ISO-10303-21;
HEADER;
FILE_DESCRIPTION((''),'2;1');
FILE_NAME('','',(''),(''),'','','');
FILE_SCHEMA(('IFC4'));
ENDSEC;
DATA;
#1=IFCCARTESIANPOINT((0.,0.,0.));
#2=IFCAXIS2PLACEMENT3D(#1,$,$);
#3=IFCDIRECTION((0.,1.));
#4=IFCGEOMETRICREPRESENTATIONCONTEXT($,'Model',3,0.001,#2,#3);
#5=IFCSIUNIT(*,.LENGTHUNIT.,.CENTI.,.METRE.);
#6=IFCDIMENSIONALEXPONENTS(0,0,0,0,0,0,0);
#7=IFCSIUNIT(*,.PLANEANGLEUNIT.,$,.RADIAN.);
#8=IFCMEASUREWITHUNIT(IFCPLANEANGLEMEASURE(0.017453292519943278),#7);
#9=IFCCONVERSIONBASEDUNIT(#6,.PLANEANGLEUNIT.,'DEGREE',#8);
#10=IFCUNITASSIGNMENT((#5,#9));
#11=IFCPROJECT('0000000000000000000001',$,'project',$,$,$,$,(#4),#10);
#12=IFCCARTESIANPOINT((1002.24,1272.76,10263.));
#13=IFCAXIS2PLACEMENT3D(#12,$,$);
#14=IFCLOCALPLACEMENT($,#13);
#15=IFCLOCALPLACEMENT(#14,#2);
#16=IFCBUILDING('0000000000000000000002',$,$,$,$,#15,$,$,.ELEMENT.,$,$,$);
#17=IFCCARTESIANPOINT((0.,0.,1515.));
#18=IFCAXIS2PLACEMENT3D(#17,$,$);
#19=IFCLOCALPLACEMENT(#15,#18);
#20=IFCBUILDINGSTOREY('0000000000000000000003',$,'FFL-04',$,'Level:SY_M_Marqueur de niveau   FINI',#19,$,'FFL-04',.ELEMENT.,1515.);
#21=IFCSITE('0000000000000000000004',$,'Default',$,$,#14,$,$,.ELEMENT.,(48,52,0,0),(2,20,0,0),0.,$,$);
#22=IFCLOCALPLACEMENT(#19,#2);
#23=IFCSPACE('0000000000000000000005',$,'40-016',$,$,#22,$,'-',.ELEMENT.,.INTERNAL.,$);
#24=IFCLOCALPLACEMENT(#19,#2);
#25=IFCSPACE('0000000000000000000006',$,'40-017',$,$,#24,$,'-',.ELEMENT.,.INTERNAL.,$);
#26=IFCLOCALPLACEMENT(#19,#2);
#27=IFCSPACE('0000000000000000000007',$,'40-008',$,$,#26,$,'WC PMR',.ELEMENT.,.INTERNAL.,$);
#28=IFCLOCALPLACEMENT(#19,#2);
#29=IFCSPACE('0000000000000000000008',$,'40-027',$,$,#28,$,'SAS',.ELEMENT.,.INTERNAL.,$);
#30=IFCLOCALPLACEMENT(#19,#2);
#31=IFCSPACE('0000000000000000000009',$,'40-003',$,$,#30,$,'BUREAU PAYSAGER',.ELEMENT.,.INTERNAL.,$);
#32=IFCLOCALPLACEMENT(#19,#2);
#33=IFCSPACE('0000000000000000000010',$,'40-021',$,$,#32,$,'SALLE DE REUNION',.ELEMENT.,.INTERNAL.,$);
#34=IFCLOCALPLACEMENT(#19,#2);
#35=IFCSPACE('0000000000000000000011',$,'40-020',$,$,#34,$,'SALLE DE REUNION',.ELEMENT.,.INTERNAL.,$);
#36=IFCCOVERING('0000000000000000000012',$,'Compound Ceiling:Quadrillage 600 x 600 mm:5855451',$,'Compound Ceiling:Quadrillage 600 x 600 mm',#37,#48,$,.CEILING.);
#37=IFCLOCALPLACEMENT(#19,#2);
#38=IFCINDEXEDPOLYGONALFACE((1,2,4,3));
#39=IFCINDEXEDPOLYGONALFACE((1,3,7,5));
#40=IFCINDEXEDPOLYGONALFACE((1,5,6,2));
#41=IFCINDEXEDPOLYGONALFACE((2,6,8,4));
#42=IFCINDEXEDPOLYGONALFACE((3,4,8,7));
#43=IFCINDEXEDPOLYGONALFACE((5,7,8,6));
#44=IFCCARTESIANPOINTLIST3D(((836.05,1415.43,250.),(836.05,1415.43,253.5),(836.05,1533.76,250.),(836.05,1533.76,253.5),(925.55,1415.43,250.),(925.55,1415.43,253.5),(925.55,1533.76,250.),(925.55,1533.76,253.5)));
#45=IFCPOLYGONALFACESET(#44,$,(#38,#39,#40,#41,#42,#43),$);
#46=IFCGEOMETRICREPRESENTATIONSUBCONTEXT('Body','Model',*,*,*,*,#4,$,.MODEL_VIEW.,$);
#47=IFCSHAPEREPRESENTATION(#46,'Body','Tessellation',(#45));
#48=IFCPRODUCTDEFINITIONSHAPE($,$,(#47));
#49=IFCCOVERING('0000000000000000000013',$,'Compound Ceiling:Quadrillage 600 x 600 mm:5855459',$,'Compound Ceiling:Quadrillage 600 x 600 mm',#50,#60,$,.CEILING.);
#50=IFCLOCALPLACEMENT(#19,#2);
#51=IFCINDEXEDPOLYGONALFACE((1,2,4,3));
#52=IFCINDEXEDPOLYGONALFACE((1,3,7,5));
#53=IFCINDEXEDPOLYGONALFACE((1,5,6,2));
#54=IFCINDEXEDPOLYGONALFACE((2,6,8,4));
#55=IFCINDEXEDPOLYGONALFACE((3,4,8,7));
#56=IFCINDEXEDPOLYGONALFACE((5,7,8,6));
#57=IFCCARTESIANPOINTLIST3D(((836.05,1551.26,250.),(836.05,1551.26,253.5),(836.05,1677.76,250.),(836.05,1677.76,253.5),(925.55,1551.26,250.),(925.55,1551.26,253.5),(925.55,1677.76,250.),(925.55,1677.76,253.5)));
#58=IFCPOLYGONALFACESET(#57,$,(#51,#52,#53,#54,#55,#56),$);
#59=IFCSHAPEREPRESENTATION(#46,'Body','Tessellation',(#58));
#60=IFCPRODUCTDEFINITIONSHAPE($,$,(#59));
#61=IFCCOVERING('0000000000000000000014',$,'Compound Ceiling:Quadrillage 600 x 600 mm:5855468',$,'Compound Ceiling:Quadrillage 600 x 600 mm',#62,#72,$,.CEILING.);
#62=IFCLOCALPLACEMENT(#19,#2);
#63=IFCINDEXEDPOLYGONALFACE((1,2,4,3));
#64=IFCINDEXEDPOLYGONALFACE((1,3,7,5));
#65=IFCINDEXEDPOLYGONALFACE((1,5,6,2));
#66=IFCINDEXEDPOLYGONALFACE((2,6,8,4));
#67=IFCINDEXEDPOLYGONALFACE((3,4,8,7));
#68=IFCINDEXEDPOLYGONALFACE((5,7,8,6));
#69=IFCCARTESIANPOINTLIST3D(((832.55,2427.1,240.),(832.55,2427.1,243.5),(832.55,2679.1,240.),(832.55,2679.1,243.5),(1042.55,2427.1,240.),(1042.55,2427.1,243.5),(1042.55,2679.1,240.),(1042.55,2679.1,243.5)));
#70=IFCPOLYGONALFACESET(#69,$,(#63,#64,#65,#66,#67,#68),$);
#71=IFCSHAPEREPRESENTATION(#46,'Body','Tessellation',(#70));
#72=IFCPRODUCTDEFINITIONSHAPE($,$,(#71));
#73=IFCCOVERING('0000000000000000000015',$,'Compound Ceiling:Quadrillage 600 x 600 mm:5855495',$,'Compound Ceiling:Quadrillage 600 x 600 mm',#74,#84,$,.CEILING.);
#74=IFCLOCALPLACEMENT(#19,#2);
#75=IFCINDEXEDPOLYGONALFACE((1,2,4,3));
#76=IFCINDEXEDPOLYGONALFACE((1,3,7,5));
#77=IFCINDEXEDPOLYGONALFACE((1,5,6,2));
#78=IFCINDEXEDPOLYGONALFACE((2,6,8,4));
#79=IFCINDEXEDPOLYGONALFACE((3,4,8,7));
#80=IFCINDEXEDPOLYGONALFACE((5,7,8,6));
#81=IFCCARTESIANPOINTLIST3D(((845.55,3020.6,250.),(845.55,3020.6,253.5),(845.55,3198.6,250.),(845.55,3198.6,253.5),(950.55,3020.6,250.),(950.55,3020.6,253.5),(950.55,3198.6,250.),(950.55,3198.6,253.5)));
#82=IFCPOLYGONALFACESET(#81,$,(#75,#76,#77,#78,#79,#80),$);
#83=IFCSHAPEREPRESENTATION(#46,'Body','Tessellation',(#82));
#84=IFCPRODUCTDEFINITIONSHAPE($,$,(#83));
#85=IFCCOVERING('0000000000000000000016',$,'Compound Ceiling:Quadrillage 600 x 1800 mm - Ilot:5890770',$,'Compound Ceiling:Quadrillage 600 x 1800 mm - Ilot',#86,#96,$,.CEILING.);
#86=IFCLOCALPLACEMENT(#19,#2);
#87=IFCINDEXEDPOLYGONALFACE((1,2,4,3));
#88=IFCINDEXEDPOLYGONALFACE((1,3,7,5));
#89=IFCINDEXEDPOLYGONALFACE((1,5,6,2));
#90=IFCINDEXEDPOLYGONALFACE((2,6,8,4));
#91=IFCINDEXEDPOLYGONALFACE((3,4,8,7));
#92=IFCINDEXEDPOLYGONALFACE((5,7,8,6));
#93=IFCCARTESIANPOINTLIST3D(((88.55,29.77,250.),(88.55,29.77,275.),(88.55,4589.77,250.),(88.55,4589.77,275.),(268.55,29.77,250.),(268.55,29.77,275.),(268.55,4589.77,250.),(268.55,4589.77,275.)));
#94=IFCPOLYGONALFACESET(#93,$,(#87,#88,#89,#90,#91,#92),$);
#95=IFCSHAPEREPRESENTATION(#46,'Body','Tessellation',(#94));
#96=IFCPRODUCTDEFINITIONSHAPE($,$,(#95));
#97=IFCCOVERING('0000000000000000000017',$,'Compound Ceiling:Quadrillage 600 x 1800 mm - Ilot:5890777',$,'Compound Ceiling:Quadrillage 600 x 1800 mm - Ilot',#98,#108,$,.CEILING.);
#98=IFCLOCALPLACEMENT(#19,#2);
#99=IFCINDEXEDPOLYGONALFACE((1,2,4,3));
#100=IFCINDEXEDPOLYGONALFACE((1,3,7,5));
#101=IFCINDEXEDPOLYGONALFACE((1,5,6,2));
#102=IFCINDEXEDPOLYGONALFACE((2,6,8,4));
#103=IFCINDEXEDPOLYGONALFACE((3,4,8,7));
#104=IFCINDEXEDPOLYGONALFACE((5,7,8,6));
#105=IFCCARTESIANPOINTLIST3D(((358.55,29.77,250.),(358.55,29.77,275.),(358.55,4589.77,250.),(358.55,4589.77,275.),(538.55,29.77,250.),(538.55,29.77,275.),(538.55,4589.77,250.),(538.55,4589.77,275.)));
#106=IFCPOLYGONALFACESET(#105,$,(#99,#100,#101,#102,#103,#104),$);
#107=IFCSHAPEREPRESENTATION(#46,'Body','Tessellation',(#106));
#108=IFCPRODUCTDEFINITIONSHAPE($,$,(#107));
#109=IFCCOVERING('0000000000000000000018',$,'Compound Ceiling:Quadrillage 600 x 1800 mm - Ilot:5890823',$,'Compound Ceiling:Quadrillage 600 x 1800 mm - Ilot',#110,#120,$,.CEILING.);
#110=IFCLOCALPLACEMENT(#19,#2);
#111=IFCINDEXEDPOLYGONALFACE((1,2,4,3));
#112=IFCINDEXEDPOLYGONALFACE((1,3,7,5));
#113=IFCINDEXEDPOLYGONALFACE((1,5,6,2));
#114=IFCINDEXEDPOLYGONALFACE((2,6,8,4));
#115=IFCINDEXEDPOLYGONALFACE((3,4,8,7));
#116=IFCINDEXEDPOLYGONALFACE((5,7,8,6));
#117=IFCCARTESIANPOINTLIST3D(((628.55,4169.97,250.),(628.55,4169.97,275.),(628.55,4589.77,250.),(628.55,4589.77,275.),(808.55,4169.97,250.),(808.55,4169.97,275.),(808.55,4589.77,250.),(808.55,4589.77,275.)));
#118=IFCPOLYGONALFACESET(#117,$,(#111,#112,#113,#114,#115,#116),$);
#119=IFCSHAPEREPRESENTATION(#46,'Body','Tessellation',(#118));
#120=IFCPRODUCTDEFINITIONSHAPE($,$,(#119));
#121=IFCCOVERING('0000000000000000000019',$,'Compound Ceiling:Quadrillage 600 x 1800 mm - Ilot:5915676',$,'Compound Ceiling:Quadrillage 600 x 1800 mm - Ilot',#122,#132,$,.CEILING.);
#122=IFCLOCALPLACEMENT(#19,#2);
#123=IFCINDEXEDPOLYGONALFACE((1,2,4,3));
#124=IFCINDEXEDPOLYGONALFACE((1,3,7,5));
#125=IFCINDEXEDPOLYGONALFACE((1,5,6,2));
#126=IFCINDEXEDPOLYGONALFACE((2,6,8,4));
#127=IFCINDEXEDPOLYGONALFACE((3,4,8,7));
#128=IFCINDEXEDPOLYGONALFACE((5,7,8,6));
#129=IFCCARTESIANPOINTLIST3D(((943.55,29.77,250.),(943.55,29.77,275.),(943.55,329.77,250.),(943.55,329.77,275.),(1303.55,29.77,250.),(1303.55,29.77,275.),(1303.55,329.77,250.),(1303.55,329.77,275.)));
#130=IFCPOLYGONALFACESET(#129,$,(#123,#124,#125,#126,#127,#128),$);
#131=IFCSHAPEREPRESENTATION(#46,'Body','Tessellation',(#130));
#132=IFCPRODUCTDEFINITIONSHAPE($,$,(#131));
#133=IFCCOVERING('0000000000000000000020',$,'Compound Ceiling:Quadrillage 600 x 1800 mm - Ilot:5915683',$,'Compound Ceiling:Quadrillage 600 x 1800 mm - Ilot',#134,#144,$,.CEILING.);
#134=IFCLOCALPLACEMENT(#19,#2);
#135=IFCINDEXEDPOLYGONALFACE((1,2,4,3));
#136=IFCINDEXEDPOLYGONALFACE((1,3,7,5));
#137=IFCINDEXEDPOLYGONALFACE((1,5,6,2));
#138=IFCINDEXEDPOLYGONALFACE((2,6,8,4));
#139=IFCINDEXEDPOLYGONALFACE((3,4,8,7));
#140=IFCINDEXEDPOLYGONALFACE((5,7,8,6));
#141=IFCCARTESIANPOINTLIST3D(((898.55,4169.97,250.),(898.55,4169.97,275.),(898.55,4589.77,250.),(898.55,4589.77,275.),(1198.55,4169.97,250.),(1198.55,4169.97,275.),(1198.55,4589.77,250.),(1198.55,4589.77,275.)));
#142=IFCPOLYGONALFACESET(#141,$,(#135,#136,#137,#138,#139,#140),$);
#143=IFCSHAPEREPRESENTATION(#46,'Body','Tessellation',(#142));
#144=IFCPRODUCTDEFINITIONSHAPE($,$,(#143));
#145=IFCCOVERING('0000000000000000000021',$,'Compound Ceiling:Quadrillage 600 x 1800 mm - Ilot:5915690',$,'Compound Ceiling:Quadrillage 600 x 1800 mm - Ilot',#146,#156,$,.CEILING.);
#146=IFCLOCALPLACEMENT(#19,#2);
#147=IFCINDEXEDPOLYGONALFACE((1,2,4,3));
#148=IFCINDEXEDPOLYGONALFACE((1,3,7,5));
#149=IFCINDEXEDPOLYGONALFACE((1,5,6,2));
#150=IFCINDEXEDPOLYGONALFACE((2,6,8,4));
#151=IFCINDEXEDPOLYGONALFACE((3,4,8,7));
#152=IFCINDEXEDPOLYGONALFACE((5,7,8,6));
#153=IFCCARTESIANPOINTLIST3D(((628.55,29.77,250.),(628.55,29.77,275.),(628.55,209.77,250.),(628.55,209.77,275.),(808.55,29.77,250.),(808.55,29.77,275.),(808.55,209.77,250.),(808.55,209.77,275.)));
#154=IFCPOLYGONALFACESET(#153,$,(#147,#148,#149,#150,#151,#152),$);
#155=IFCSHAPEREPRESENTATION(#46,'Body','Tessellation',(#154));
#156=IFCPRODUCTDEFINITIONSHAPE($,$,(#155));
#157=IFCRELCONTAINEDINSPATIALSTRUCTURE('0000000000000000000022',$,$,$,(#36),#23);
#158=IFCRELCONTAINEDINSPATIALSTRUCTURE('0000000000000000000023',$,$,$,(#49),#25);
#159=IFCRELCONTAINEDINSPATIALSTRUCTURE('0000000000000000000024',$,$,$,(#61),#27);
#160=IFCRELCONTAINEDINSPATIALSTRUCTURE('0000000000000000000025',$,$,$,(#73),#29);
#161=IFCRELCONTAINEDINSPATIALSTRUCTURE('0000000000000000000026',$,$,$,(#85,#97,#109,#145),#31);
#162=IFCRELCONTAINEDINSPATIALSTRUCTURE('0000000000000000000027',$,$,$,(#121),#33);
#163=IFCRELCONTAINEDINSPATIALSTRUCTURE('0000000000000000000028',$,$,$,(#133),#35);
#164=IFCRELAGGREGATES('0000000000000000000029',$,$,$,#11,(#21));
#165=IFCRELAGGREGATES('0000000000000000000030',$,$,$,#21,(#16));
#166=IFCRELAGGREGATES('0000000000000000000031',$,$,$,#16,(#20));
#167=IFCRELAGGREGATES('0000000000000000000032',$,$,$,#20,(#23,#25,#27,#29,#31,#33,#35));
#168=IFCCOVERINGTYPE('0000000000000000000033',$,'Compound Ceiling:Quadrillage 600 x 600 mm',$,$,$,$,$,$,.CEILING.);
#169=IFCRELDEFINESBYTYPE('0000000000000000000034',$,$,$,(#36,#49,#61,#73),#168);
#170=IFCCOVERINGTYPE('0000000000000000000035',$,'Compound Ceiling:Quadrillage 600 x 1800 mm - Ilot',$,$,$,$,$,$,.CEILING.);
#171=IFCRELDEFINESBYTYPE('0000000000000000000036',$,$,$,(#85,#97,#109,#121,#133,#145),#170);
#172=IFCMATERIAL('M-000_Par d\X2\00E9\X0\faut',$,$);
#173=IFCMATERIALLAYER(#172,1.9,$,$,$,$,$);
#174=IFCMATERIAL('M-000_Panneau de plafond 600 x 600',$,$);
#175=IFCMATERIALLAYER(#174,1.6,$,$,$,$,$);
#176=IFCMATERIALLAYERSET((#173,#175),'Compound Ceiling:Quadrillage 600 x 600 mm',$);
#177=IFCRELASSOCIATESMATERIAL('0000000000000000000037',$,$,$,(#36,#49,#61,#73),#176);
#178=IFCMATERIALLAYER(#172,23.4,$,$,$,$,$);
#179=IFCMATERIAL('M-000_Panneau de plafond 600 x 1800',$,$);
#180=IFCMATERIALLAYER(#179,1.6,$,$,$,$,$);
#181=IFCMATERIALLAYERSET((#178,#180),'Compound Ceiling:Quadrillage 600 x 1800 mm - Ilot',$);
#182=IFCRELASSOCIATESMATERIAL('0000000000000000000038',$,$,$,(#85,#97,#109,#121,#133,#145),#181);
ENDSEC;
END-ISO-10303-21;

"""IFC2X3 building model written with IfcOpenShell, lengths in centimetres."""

from ifc_helpers import new_model, entity, si_unit, converted_unit, direction, frame, frame_2d, origin, origin_2d_with_axis, place, context, subcontext, project, spatial, polyline, rectangle, outline, extrude, material, layer, layer_set, layer_usage, type_object, element, save


model = new_model("IFC2X3")

# Units and contexts
model_context = context("Model", 3, precision=0.001, world=origin(), true_north=direction((0.0, 1.0)))
body_context = subcontext(model_context, "Body", "Model", "MODEL_VIEW")
ifc_project = project(units=[si_unit("LENGTHUNIT", "METRE", prefix="CENTI"), converted_unit("PLANEANGLEUNIT", "DEGREE", entity("IfcPlaneAngleMeasure", 0.017453292519943278), si_unit("PLANEANGLEUNIT", "RADIAN"), dimensions=[0, 0, 0, 0, 0, 0, 0])], contexts=[model_context])

# Site, building, storey
site_placement = place(None, frame((1002.24, 1272.76, 10263.0)))
site = spatial("IfcSite", under=ifc_project, at=site_placement, Name="Default", CompositionType="ELEMENT", RefLatitude=(48, 52, 0, 0), RefLongitude=(2, 20, 0, 0), RefElevation=0.0)
building_placement = place(site_placement, origin())
building = spatial("IfcBuilding", under=site, at=building_placement, CompositionType="ELEMENT")
storey_placement = place(building_placement, frame((0.0, 0.0, 1515.0)))
storey = spatial("IfcBuildingStorey", under=building, at=storey_placement, Name="FFL-04", ObjectType="Level:SY_M_Marqueur de niveau   FINI", LongName="FFL-04", CompositionType="ELEMENT", Elevation=1515.0)

# Shared definitions
ifc_material_1 = material(Name="M-000_Par défaut")
ifc_layer_1 = layer(ifc_material_1, 1.9)
ifc_material_2 = material(Name="M-000_Panneau de plafond 600 x 600")
ifc_layer_2 = layer(ifc_material_2, 1.6)
ifc_layer_set_1 = layer_set([ifc_layer_1, ifc_layer_2], Name="Compound Ceiling:Quadrillage 600 x 600 mm")
covering_type_1 = type_object("IfcCoveringType", Name="Compound Ceiling:Quadrillage 600 x 600 mm", PredefinedType="CEILING")

# Shared definitions
space_1_placement = place(storey_placement, origin())
space_1 = spatial("IfcSpace", under=storey, at=space_1_placement, Name="40-016", LongName="-", CompositionType="ELEMENT", InteriorOrExteriorSpace="INTERNAL")

# Covering
ifc_layer_usage_1 = layer_usage(ifc_layer_set_1, "AXIS3", "NEGATIVE", 3.5)
covering_1_placement = place(space_1_placement, origin())
element("IfcCovering", 1, at=covering_1_placement, inside=space_1, type_object=covering_type_1, material=ifc_layer_usage_1, Name="Compound Ceiling:Quadrillage 600 x 600 mm:5855451", ObjectType="Compound Ceiling:Quadrillage 600 x 600 mm", PredefinedType="CEILING", context=body_context, shape_type="SweptSolid", body=[
    extrude(rectangle(XDim=118.33, YDim=89.49, at=frame_2d((0.0, 0.0), x_axis=(1.0, 0.0))), frame((880.8, 1474.6, 250.0), z_axis=(0.0, 0.0, 1.0), x_axis=(0.0, -1.0, 0.0)), (0.0, 0.0, 1.0), 3.5),
])

# Shared definitions
space_2_placement = place(storey_placement, origin())
space_2 = spatial("IfcSpace", under=storey, at=space_2_placement, Name="40-017", LongName="-", CompositionType="ELEMENT", InteriorOrExteriorSpace="INTERNAL")

# Covering
ifc_layer_usage_2 = layer_usage(ifc_layer_set_1, "AXIS3", "NEGATIVE", 3.5)
covering_2_placement = place(space_2_placement, origin())
element("IfcCovering", 2, at=covering_2_placement, inside=space_2, type_object=covering_type_1, material=ifc_layer_usage_2, Name="Compound Ceiling:Quadrillage 600 x 600 mm:5855459", ObjectType="Compound Ceiling:Quadrillage 600 x 600 mm", PredefinedType="CEILING", context=body_context, shape_type="SweptSolid", body=[
    extrude(outline(polyline([(-63.25, -44.75), (63.25, -44.75), (63.25, 44.75), (-63.25, 44.75), (-63.25, -44.75)])), frame((880.8, 1614.51, 250.0), z_axis=(0.0, 0.0, 1.0), x_axis=(0.0, -1.0, 0.0)), (0.0, 0.0, 1.0), 3.5),
])

# Shared definitions
space_3_placement = place(storey_placement, origin())
space_3 = spatial("IfcSpace", under=storey, at=space_3_placement, Name="40-008", LongName="WC PMR", CompositionType="ELEMENT", InteriorOrExteriorSpace="INTERNAL")

# Covering
ifc_layer_usage_3 = layer_usage(ifc_layer_set_1, "AXIS3", "NEGATIVE", 3.5)
covering_3_placement = place(space_3_placement, origin())
element("IfcCovering", 3, at=covering_3_placement, inside=space_3, type_object=covering_type_1, material=ifc_layer_usage_3, Name="Compound Ceiling:Quadrillage 600 x 600 mm:5855468", ObjectType="Compound Ceiling:Quadrillage 600 x 600 mm", PredefinedType="CEILING", context=body_context, shape_type="SweptSolid", body=[
    extrude(rectangle(XDim=210.0, YDim=252.0, at=frame_2d((0.0, 0.0), x_axis=(1.0, 0.0))), frame((937.55, 2553.1, 240.0)), (0.0, 0.0, 1.0), 3.5),
])

# Shared definitions
space_4_placement = place(storey_placement, origin())
space_4 = spatial("IfcSpace", under=storey, at=space_4_placement, Name="40-027", LongName="SAS", CompositionType="ELEMENT", InteriorOrExteriorSpace="INTERNAL")

# Covering
ifc_layer_usage_4 = layer_usage(ifc_layer_set_1, "AXIS3", "NEGATIVE", 3.5)
covering_4_placement = place(space_4_placement, origin())
element("IfcCovering", 4, at=covering_4_placement, inside=space_4, type_object=covering_type_1, material=ifc_layer_usage_4, Name="Compound Ceiling:Quadrillage 600 x 600 mm:5855495", ObjectType="Compound Ceiling:Quadrillage 600 x 600 mm", PredefinedType="CEILING", context=body_context, shape_type="SweptSolid", body=[
    extrude(rectangle(XDim=178.0, YDim=104.99, at=frame_2d((0.0, 0.0), x_axis=(1.0, 0.0))), frame((898.05, 3109.6, 250.0), z_axis=(0.0, 0.0, 1.0), x_axis=(0.0, 1.0, 0.0)), (0.0, 0.0, 1.0), 3.5),
])

# Shared definitions
space_5_placement = place(storey_placement, origin())
space_5 = spatial("IfcSpace", under=storey, at=space_5_placement, Name="40-003", LongName="BUREAU PAYSAGER", CompositionType="ELEMENT", InteriorOrExteriorSpace="INTERNAL")

# Coverings
ifc_layer_3 = layer(ifc_material_1, 23.4)
ifc_material_3 = material(Name="M-000_Panneau de plafond 600 x 1800")
ifc_layer_4 = layer(ifc_material_3, 1.6)
ifc_layer_set_2 = layer_set([ifc_layer_3, ifc_layer_4], Name="Compound Ceiling:Quadrillage 600 x 1800 mm - Ilot")
ifc_layer_usage_5 = layer_usage(ifc_layer_set_2, "AXIS3", "NEGATIVE", 25.0)
covering_type_2 = type_object("IfcCoveringType", Name="Compound Ceiling:Quadrillage 600 x 1800 mm - Ilot", PredefinedType="CEILING")
covering_5_placement = place(space_5_placement, origin())
element("IfcCovering", 5, at=covering_5_placement, inside=space_5, type_object=covering_type_2, material=ifc_layer_usage_5, Name="Compound Ceiling:Quadrillage 600 x 1800 mm - Ilot:5890770", ObjectType="Compound Ceiling:Quadrillage 600 x 1800 mm - Ilot", PredefinedType="CEILING", context=body_context, shape_type="SweptSolid", body=[
    extrude(rectangle(XDim=180.0, YDim=4560.0, at=origin_2d_with_axis()), frame((178.55, 2309.77, 250.0), z_axis=(0.0, 0.0, 1.0), x_axis=(-1.0, 0.0, 0.0)), (0.0, 0.0, 1.0), 25.0),
])
ifc_layer_usage_6 = layer_usage(ifc_layer_set_2, "AXIS3", "NEGATIVE", 25.0)
covering_6_placement = place(space_5_placement, origin())
element("IfcCovering", 6, at=covering_6_placement, inside=space_5, type_object=covering_type_2, material=ifc_layer_usage_6, Name="Compound Ceiling:Quadrillage 600 x 1800 mm - Ilot:5890777", ObjectType="Compound Ceiling:Quadrillage 600 x 1800 mm - Ilot", PredefinedType="CEILING", context=body_context, shape_type="SweptSolid", body=[
    extrude(rectangle(XDim=180.0, YDim=4560.0, at=origin_2d_with_axis()), frame((448.55, 2309.77, 250.0), z_axis=(0.0, 0.0, 1.0), x_axis=(-1.0, 0.0, 0.0)), (0.0, 0.0, 1.0), 25.0),
])
ifc_layer_usage_7 = layer_usage(ifc_layer_set_2, "AXIS3", "NEGATIVE", 25.0)
covering_7_placement = place(space_5_placement, origin())
element("IfcCovering", 7, at=covering_7_placement, inside=space_5, type_object=covering_type_2, material=ifc_layer_usage_7, Name="Compound Ceiling:Quadrillage 600 x 1800 mm - Ilot:5890823", ObjectType="Compound Ceiling:Quadrillage 600 x 1800 mm - Ilot", PredefinedType="CEILING", context=body_context, shape_type="SweptSolid", body=[
    extrude(rectangle(XDim=180.0, YDim=419.79, at=frame_2d((0.0, 0.0), x_axis=(1.0, 0.0))), frame((718.55, 4379.87, 250.0), z_axis=(0.0, 0.0, 1.0), x_axis=(-1.0, 0.0, 0.0)), (0.0, 0.0, 1.0), 25.0),
])

# Shared definitions
space_6_placement = place(storey_placement, origin())
space_6 = spatial("IfcSpace", under=storey, at=space_6_placement, Name="40-021", LongName="SALLE DE REUNION", CompositionType="ELEMENT", InteriorOrExteriorSpace="INTERNAL")

# Covering
ifc_layer_usage_8 = layer_usage(ifc_layer_set_2, "AXIS3", "NEGATIVE", 25.0)
covering_8_placement = place(space_6_placement, origin())
element("IfcCovering", 8, at=covering_8_placement, inside=space_6, type_object=covering_type_2, material=ifc_layer_usage_8, Name="Compound Ceiling:Quadrillage 600 x 1800 mm - Ilot:5915676", ObjectType="Compound Ceiling:Quadrillage 600 x 1800 mm - Ilot", PredefinedType="CEILING", context=body_context, shape_type="SweptSolid", body=[
    extrude(rectangle(XDim=360.0, YDim=300.0, at=origin_2d_with_axis()), frame((1123.55, 179.77, 250.0), z_axis=(0.0, 0.0, 1.0), x_axis=(-1.0, 0.0, 0.0)), (0.0, 0.0, 1.0), 25.0),
])

# Shared definitions
space_7_placement = place(storey_placement, origin())
space_7 = spatial("IfcSpace", under=storey, at=space_7_placement, Name="40-020", LongName="SALLE DE REUNION", CompositionType="ELEMENT", InteriorOrExteriorSpace="INTERNAL")

# Coverings
ifc_layer_usage_9 = layer_usage(ifc_layer_set_2, "AXIS3", "NEGATIVE", 25.0)
covering_9_placement = place(space_7_placement, origin())
element("IfcCovering", 9, at=covering_9_placement, inside=space_7, type_object=covering_type_2, material=ifc_layer_usage_9, Name="Compound Ceiling:Quadrillage 600 x 1800 mm - Ilot:5915683", ObjectType="Compound Ceiling:Quadrillage 600 x 1800 mm - Ilot", PredefinedType="CEILING", context=body_context, shape_type="SweptSolid", body=[
    extrude(rectangle(XDim=300.0, YDim=419.79, at=frame_2d((0.0, 0.0), x_axis=(1.0, 0.0))), frame((1048.55, 4379.87, 250.0), z_axis=(0.0, 0.0, 1.0), x_axis=(-1.0, 0.0, 0.0)), (0.0, 0.0, 1.0), 25.0),
])
ifc_layer_usage_10 = layer_usage(ifc_layer_set_2, "AXIS3", "NEGATIVE", 25.0)
covering_10_placement = place(space_5_placement, origin())
element("IfcCovering", 10, at=covering_10_placement, inside=space_5, type_object=covering_type_2, material=ifc_layer_usage_10, Name="Compound Ceiling:Quadrillage 600 x 1800 mm - Ilot:5915690", ObjectType="Compound Ceiling:Quadrillage 600 x 1800 mm - Ilot", PredefinedType="CEILING", context=body_context, shape_type="SweptSolid", body=[
    extrude(rectangle(XDim=180.0, YDim=180.0, at=origin_2d_with_axis()), frame((718.55, 119.77, 250.0), z_axis=(0.0, 0.0, 1.0), x_axis=(-1.0, 0.0, 0.0)), (0.0, 0.0, 1.0), 25.0),
])

save(model, "model.ifc")
